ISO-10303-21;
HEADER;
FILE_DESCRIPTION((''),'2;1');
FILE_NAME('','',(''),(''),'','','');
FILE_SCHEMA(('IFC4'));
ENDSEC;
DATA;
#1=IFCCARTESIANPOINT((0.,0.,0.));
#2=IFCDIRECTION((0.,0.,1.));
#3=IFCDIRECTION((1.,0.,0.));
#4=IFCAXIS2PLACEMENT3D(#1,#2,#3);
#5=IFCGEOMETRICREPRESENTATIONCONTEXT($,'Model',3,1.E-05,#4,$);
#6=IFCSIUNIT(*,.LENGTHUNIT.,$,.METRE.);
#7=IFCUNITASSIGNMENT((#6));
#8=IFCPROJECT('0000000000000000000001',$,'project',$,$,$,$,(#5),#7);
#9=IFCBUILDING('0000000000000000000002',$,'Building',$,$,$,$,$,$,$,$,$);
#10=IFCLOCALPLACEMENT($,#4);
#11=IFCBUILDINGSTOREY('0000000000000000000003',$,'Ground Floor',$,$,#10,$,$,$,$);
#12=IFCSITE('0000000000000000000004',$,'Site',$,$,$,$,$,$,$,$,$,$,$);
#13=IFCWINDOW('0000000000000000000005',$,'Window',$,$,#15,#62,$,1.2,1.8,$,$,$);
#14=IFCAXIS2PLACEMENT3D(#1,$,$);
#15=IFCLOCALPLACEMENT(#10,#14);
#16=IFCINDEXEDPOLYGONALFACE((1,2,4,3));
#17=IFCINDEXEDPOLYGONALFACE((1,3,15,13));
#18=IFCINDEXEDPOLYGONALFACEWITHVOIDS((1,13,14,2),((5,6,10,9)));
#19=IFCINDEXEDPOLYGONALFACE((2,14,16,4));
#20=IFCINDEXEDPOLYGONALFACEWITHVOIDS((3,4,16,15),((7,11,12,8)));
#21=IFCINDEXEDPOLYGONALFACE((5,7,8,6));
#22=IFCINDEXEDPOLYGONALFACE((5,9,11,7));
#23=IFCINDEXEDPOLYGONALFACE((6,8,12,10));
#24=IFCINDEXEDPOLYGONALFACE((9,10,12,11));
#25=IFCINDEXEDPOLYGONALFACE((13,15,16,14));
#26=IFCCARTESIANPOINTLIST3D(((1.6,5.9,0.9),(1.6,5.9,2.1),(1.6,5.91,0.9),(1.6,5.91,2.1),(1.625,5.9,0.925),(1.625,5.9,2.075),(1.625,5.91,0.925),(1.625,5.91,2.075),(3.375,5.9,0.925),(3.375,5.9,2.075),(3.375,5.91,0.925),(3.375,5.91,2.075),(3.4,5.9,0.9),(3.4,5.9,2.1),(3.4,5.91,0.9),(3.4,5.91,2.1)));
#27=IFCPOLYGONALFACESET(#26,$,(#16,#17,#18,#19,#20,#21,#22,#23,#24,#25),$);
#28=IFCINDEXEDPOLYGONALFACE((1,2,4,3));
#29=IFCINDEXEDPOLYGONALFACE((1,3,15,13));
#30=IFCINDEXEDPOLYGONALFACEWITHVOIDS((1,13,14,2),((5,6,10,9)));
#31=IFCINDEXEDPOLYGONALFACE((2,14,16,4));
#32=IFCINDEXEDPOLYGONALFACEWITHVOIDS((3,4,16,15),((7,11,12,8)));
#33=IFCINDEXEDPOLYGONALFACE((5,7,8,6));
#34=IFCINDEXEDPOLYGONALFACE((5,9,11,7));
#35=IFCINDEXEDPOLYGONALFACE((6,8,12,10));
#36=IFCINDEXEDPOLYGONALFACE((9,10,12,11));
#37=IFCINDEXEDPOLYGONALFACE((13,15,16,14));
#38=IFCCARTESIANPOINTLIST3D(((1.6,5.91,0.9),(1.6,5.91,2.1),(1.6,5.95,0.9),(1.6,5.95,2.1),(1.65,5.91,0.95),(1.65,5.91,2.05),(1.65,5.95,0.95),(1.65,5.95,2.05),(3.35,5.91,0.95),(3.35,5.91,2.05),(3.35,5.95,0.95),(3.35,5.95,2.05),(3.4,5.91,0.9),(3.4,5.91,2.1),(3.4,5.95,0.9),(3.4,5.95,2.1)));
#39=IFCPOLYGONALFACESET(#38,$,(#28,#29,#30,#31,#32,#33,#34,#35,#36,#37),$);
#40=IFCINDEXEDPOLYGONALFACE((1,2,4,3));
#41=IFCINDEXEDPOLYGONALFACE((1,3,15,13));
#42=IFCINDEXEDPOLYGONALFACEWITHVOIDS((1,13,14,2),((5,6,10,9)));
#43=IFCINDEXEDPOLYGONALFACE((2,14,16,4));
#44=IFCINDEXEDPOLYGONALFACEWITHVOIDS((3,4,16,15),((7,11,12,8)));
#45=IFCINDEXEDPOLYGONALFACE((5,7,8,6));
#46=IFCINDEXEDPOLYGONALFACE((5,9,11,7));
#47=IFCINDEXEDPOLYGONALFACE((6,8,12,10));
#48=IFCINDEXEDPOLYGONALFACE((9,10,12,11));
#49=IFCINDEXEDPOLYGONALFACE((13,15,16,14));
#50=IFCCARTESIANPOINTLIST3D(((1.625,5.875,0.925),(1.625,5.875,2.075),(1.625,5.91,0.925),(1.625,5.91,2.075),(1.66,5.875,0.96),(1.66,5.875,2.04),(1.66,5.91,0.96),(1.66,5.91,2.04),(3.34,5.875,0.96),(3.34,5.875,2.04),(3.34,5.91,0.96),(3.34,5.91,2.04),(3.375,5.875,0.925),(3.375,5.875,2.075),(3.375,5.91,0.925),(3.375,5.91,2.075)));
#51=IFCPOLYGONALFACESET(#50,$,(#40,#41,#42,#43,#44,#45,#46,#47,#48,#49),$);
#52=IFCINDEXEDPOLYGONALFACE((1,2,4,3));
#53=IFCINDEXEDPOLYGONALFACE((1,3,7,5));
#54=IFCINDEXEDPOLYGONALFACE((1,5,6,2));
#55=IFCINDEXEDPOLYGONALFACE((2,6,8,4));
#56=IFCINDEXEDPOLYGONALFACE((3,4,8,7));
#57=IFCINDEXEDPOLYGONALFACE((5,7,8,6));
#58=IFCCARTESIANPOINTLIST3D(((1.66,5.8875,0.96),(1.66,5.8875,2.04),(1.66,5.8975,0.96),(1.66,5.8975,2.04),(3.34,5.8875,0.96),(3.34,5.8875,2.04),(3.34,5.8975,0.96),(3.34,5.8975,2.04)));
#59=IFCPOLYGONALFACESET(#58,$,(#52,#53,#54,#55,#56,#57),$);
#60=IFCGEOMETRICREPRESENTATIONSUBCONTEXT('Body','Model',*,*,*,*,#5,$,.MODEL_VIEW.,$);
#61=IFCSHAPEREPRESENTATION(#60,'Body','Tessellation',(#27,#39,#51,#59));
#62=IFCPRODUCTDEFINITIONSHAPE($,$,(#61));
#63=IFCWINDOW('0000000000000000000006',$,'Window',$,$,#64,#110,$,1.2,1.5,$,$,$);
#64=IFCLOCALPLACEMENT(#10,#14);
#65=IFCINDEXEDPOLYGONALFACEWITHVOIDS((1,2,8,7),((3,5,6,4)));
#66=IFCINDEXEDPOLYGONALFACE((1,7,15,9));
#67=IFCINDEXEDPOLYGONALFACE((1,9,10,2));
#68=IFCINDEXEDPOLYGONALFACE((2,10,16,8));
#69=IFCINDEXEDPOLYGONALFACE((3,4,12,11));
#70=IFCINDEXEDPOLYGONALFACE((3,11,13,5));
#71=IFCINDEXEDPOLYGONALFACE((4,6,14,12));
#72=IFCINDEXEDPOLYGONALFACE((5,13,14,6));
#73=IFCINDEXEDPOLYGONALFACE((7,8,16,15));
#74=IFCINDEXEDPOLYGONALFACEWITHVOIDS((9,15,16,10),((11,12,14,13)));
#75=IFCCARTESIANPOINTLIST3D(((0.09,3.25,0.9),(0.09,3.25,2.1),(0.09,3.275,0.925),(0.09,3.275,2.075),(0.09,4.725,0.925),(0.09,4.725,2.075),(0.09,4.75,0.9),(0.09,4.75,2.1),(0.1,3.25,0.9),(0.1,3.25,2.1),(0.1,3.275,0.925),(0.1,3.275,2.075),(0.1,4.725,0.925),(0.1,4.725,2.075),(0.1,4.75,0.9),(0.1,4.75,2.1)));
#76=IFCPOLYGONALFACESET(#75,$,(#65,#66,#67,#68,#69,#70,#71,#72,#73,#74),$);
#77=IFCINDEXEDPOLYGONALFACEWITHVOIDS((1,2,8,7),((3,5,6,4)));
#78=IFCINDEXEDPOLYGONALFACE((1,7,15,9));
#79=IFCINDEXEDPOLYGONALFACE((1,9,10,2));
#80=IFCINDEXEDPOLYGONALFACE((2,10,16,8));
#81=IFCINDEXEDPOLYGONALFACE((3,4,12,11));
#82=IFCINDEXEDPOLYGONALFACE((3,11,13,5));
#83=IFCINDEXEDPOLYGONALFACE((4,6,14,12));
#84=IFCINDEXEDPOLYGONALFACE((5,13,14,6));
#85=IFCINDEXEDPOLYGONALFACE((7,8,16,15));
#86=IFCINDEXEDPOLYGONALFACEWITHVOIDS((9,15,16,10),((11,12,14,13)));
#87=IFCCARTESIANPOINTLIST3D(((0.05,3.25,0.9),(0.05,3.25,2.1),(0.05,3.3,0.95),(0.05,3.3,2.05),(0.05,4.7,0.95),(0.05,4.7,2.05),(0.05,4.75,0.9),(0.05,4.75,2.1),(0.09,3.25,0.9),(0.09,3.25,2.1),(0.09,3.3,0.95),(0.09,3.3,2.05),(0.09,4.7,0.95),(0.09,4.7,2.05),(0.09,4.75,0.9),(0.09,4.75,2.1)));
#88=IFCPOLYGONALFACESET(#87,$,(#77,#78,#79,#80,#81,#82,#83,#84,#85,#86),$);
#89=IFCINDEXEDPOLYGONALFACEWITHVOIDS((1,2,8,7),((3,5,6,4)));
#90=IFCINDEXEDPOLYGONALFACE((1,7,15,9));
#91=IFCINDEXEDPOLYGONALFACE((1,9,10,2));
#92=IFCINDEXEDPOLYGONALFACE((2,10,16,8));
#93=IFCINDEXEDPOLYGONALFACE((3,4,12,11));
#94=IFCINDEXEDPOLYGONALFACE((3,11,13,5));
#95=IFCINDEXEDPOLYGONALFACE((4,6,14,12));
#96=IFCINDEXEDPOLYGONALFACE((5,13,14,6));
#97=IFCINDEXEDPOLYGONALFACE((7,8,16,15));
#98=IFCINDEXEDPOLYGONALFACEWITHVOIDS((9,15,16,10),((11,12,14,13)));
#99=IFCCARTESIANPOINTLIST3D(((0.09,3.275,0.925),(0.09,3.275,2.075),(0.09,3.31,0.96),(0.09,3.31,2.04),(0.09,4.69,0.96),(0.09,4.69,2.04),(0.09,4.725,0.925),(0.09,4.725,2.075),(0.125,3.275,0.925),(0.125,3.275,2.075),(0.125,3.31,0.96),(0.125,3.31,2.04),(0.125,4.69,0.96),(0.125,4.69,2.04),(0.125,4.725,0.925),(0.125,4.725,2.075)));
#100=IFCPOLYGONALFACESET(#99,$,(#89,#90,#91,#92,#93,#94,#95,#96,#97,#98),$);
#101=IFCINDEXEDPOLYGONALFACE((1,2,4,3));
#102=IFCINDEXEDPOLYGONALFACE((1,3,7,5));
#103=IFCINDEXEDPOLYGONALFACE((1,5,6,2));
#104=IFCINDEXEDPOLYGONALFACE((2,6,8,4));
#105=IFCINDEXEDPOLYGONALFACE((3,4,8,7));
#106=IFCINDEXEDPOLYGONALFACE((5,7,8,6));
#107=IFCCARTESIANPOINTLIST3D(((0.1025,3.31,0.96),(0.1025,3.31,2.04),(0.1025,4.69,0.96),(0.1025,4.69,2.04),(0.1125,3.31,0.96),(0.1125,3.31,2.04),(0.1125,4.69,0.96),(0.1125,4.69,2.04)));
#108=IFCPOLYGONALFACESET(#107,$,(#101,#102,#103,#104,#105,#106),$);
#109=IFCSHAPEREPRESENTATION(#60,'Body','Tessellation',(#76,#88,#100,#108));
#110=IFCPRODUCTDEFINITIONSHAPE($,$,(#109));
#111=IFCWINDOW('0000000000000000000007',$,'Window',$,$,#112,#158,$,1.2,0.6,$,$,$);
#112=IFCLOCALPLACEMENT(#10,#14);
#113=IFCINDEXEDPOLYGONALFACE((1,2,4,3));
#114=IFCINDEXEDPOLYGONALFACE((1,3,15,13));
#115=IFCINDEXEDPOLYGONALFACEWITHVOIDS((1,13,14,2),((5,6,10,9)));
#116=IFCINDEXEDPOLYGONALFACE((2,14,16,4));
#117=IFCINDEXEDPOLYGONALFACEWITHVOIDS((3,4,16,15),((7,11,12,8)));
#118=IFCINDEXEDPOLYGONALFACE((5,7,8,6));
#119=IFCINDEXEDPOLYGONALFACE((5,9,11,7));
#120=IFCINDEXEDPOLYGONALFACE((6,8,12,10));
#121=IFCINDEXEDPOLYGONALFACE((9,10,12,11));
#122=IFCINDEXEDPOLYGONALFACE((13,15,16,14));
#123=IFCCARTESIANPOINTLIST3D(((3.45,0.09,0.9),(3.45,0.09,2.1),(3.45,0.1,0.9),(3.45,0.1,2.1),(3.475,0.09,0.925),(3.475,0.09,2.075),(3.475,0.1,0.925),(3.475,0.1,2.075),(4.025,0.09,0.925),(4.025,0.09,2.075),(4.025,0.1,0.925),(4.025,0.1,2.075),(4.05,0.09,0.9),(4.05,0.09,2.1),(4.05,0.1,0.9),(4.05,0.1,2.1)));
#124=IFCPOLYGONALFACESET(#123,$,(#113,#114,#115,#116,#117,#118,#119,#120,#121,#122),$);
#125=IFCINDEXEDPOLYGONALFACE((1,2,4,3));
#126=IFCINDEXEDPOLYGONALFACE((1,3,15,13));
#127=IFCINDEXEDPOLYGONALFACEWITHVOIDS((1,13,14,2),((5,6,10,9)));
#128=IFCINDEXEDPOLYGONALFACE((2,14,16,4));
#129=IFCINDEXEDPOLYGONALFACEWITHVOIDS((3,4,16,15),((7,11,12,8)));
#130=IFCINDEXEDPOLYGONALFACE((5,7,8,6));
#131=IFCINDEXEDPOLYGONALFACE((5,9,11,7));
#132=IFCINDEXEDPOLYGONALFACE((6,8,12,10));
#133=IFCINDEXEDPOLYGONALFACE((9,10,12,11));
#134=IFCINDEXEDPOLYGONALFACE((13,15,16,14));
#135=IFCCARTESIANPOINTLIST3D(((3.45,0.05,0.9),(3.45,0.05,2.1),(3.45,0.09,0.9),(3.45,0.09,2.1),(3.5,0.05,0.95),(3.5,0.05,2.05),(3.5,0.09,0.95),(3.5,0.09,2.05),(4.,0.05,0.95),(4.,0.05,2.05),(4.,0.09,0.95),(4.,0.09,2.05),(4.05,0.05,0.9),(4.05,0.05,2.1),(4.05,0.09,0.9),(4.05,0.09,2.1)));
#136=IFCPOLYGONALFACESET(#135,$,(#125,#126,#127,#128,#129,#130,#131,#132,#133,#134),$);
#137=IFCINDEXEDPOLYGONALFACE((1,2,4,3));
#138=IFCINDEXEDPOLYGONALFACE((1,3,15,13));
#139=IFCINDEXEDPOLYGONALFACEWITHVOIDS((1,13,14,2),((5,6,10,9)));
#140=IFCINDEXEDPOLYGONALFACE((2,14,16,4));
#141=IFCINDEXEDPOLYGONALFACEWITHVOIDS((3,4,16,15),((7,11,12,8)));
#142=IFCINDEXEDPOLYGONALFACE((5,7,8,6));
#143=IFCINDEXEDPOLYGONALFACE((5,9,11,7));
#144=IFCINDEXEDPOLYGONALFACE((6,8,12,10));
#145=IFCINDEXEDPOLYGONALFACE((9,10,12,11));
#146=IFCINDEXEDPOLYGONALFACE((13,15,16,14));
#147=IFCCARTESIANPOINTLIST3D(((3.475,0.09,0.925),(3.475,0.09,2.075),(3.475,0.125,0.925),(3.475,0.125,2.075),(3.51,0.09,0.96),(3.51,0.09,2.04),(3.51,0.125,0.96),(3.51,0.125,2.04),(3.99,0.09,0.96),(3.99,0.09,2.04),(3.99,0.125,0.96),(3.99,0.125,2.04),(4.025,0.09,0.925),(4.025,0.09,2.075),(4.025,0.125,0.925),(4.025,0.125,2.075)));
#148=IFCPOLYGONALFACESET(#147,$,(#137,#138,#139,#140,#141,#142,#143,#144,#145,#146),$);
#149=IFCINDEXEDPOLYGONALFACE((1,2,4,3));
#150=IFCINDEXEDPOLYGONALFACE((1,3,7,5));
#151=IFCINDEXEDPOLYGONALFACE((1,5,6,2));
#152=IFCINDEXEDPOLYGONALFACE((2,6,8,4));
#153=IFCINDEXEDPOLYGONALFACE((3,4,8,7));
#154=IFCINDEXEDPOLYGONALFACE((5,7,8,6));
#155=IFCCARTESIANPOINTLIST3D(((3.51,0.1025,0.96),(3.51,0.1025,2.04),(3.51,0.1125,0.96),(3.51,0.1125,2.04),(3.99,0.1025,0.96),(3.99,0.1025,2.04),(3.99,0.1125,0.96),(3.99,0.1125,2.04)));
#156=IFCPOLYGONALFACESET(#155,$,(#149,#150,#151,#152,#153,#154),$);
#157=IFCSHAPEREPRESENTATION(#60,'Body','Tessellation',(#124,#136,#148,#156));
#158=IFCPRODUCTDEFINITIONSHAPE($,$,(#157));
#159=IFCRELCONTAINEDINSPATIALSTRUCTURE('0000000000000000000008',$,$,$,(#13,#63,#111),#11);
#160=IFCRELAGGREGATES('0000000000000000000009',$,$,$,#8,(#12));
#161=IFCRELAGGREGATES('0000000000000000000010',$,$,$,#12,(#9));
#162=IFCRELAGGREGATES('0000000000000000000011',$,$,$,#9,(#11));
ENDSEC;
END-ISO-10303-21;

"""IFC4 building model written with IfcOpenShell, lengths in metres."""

from ifc_helpers import new_model, si_unit, frame, origin_with_axes, place, context, subcontext, project, spatial, line, indexed_curve, outline, extrude, element, save


model = new_model("IFC4")

# Units and contexts
model_context = context("Model", 3, precision=1e-05, world=origin_with_axes())
body_context = subcontext(model_context, "Body", "Model", "MODEL_VIEW")
ifc_project = project(units=[si_unit("LENGTHUNIT", "METRE")], contexts=[model_context])

# Site, building, storey
site = spatial("IfcSite", under=ifc_project, Name="Site")
building = spatial("IfcBuilding", under=site, Name="Building")
storey_placement = place(None, origin_with_axes())
storey = spatial("IfcBuildingStorey", under=building, at=storey_placement, Name="Ground Floor")

# Windows
window_1_placement = place(storey_placement, frame((3.4, 6.0, 0.9), z_axis=(0.0, 0.0, 1.0), x_axis=(-1.0, 0.0, 0.0)))
element("IfcWindow", 1, at=window_1_placement, inside=storey, Name="Window", OverallHeight=1.2, OverallWidth=1.8, context=body_context, shape_type="SweptSolid", body=[
    extrude(outline(indexed_curve([(0.0, 0.0), (1.8, 0.0), (1.8, 1.2), (0.0, 1.2)], segments=[line(1, 2, 3, 4, 1)]), holes=[indexed_curve([(0.025, 0.025), (1.775, 0.025), (1.775, 1.175), (0.025, 1.175)], segments=[line(1, 2, 3, 4, 1)])]), frame((0.0, 0.09, 0.0), z_axis=(0.0, -1.0, 0.0), x_axis=(1.0, 0.0, 0.0)), (0.0, 0.0, -1.0), 0.01),
    extrude(outline(indexed_curve([(0.0, 0.0), (1.8, 0.0), (1.8, 1.2), (0.0, 1.2)], segments=[line(1, 2, 3, 4, 1)]), holes=[indexed_curve([(0.05, 0.05), (1.75, 0.05), (1.75, 1.15), (0.05, 1.15)], segments=[line(1, 2, 3, 4, 1)])]), frame((0.0, 0.05, 0.0), z_axis=(0.0, -1.0, 0.0), x_axis=(1.0, 0.0, 0.0)), (0.0, 0.0, -1.0), 0.04),
    extrude(outline(indexed_curve([(0.0, 0.0), (1.75, 0.0), (1.75, 1.15), (0.0, 1.15)], segments=[line(1, 2, 3, 4, 1)]), holes=[indexed_curve([(0.035, 0.035), (1.715, 0.035), (1.715, 1.115), (0.035, 1.115)], segments=[line(1, 2, 3, 4, 1)])]), frame((0.025, 0.09, 0.025), z_axis=(0.0, -1.0, 0.0), x_axis=(1.0, 0.0, 0.0)), (0.0, 0.0, -1.0), 0.035),
    extrude(outline(indexed_curve([(0.035, 0.035), (1.715, 0.035), (1.715, 1.115), (0.035, 1.115)], segments=[line(1, 2, 3, 4, 1)])), frame((0.025, 0.1025, 0.025), z_axis=(0.0, -1.0, 0.0), x_axis=(1.0, 0.0, 0.0)), (0.0, 0.0, -1.0), 0.01),
])
window_2_placement = place(storey_placement, frame((0.0, 4.75, 0.9), z_axis=(0.0, 0.0, 1.0), x_axis=(0.0, -1.0, 0.0)))
element("IfcWindow", 2, at=window_2_placement, inside=storey, Name="Window", OverallHeight=1.2, OverallWidth=1.5, context=body_context, shape_type="SweptSolid", body=[
    extrude(outline(indexed_curve([(0.0, 0.0), (1.5, 0.0), (1.5, 1.2), (0.0, 1.2)], segments=[line(1, 2, 3, 4, 1)]), holes=[indexed_curve([(0.025, 0.025), (1.475, 0.025), (1.475, 1.175), (0.025, 1.175)], segments=[line(1, 2, 3, 4, 1)])]), frame((0.0, 0.09, 0.0), z_axis=(0.0, -1.0, 0.0), x_axis=(1.0, 0.0, 0.0)), (0.0, 0.0, -1.0), 0.01),
    extrude(outline(indexed_curve([(0.0, 0.0), (1.5, 0.0), (1.5, 1.2), (0.0, 1.2)], segments=[line(1, 2, 3, 4, 1)]), holes=[indexed_curve([(0.05, 0.05), (1.45, 0.05), (1.45, 1.15), (0.05, 1.15)], segments=[line(1, 2, 3, 4, 1)])]), frame((0.0, 0.05, 0.0), z_axis=(0.0, -1.0, 0.0), x_axis=(1.0, 0.0, 0.0)), (0.0, 0.0, -1.0), 0.04),
    extrude(outline(indexed_curve([(0.0, 0.0), (1.45, 0.0), (1.45, 1.15), (0.0, 1.15)], segments=[line(1, 2, 3, 4, 1)]), holes=[indexed_curve([(0.035, 0.035), (1.415, 0.035), (1.415, 1.115), (0.035, 1.115)], segments=[line(1, 2, 3, 4, 1)])]), frame((0.025, 0.09, 0.025), z_axis=(0.0, -1.0, 0.0), x_axis=(1.0, 0.0, 0.0)), (0.0, 0.0, -1.0), 0.035),
    extrude(outline(indexed_curve([(0.035, 0.035), (1.415, 0.035), (1.415, 1.115), (0.035, 1.115)], segments=[line(1, 2, 3, 4, 1)])), frame((0.025, 0.1025, 0.025), z_axis=(0.0, -1.0, 0.0), x_axis=(1.0, 0.0, 0.0)), (0.0, 0.0, -1.0), 0.01),
])
window_3_placement = place(storey_placement, frame((3.45, 0.0, 0.9), z_axis=(0.0, 0.0, 1.0), x_axis=(1.0, 0.0, 0.0)))
element("IfcWindow", 3, at=window_3_placement, inside=storey, Name="Window", OverallHeight=1.2, OverallWidth=0.6, context=body_context, shape_type="SweptSolid", body=[
    extrude(outline(indexed_curve([(0.0, 0.0), (0.6, 0.0), (0.6, 1.2), (0.0, 1.2)], segments=[line(1, 2, 3, 4, 1)]), holes=[indexed_curve([(0.025, 0.025), (0.575, 0.025), (0.575, 1.175), (0.025, 1.175)], segments=[line(1, 2, 3, 4, 1)])]), frame((0.0, 0.09, 0.0), z_axis=(0.0, -1.0, 0.0), x_axis=(1.0, 0.0, 0.0)), (0.0, 0.0, -1.0), 0.01),
    extrude(outline(indexed_curve([(0.0, 0.0), (0.6, 0.0), (0.6, 1.2), (0.0, 1.2)], segments=[line(1, 2, 3, 4, 1)]), holes=[indexed_curve([(0.05, 0.05), (0.55, 0.05), (0.55, 1.15), (0.05, 1.15)], segments=[line(1, 2, 3, 4, 1)])]), frame((0.0, 0.05, 0.0), z_axis=(0.0, -1.0, 0.0), x_axis=(1.0, 0.0, 0.0)), (0.0, 0.0, -1.0), 0.04),
    extrude(outline(indexed_curve([(0.0, 0.0), (0.55, 0.0), (0.55, 1.15), (0.0, 1.15)], segments=[line(1, 2, 3, 4, 1)]), holes=[indexed_curve([(0.035, 0.035), (0.515, 0.035), (0.515, 1.115), (0.035, 1.115)], segments=[line(1, 2, 3, 4, 1)])]), frame((0.025, 0.09, 0.025), z_axis=(0.0, -1.0, 0.0), x_axis=(1.0, 0.0, 0.0)), (0.0, 0.0, -1.0), 0.035),
    extrude(outline(indexed_curve([(0.035, 0.035), (0.515, 0.035), (0.515, 1.115), (0.035, 1.115)], segments=[line(1, 2, 3, 4, 1)])), frame((0.025, 0.1025, 0.025), z_axis=(0.0, -1.0, 0.0), x_axis=(1.0, 0.0, 0.0)), (0.0, 0.0, -1.0), 0.01),
])

save(model, "model.ifc")
